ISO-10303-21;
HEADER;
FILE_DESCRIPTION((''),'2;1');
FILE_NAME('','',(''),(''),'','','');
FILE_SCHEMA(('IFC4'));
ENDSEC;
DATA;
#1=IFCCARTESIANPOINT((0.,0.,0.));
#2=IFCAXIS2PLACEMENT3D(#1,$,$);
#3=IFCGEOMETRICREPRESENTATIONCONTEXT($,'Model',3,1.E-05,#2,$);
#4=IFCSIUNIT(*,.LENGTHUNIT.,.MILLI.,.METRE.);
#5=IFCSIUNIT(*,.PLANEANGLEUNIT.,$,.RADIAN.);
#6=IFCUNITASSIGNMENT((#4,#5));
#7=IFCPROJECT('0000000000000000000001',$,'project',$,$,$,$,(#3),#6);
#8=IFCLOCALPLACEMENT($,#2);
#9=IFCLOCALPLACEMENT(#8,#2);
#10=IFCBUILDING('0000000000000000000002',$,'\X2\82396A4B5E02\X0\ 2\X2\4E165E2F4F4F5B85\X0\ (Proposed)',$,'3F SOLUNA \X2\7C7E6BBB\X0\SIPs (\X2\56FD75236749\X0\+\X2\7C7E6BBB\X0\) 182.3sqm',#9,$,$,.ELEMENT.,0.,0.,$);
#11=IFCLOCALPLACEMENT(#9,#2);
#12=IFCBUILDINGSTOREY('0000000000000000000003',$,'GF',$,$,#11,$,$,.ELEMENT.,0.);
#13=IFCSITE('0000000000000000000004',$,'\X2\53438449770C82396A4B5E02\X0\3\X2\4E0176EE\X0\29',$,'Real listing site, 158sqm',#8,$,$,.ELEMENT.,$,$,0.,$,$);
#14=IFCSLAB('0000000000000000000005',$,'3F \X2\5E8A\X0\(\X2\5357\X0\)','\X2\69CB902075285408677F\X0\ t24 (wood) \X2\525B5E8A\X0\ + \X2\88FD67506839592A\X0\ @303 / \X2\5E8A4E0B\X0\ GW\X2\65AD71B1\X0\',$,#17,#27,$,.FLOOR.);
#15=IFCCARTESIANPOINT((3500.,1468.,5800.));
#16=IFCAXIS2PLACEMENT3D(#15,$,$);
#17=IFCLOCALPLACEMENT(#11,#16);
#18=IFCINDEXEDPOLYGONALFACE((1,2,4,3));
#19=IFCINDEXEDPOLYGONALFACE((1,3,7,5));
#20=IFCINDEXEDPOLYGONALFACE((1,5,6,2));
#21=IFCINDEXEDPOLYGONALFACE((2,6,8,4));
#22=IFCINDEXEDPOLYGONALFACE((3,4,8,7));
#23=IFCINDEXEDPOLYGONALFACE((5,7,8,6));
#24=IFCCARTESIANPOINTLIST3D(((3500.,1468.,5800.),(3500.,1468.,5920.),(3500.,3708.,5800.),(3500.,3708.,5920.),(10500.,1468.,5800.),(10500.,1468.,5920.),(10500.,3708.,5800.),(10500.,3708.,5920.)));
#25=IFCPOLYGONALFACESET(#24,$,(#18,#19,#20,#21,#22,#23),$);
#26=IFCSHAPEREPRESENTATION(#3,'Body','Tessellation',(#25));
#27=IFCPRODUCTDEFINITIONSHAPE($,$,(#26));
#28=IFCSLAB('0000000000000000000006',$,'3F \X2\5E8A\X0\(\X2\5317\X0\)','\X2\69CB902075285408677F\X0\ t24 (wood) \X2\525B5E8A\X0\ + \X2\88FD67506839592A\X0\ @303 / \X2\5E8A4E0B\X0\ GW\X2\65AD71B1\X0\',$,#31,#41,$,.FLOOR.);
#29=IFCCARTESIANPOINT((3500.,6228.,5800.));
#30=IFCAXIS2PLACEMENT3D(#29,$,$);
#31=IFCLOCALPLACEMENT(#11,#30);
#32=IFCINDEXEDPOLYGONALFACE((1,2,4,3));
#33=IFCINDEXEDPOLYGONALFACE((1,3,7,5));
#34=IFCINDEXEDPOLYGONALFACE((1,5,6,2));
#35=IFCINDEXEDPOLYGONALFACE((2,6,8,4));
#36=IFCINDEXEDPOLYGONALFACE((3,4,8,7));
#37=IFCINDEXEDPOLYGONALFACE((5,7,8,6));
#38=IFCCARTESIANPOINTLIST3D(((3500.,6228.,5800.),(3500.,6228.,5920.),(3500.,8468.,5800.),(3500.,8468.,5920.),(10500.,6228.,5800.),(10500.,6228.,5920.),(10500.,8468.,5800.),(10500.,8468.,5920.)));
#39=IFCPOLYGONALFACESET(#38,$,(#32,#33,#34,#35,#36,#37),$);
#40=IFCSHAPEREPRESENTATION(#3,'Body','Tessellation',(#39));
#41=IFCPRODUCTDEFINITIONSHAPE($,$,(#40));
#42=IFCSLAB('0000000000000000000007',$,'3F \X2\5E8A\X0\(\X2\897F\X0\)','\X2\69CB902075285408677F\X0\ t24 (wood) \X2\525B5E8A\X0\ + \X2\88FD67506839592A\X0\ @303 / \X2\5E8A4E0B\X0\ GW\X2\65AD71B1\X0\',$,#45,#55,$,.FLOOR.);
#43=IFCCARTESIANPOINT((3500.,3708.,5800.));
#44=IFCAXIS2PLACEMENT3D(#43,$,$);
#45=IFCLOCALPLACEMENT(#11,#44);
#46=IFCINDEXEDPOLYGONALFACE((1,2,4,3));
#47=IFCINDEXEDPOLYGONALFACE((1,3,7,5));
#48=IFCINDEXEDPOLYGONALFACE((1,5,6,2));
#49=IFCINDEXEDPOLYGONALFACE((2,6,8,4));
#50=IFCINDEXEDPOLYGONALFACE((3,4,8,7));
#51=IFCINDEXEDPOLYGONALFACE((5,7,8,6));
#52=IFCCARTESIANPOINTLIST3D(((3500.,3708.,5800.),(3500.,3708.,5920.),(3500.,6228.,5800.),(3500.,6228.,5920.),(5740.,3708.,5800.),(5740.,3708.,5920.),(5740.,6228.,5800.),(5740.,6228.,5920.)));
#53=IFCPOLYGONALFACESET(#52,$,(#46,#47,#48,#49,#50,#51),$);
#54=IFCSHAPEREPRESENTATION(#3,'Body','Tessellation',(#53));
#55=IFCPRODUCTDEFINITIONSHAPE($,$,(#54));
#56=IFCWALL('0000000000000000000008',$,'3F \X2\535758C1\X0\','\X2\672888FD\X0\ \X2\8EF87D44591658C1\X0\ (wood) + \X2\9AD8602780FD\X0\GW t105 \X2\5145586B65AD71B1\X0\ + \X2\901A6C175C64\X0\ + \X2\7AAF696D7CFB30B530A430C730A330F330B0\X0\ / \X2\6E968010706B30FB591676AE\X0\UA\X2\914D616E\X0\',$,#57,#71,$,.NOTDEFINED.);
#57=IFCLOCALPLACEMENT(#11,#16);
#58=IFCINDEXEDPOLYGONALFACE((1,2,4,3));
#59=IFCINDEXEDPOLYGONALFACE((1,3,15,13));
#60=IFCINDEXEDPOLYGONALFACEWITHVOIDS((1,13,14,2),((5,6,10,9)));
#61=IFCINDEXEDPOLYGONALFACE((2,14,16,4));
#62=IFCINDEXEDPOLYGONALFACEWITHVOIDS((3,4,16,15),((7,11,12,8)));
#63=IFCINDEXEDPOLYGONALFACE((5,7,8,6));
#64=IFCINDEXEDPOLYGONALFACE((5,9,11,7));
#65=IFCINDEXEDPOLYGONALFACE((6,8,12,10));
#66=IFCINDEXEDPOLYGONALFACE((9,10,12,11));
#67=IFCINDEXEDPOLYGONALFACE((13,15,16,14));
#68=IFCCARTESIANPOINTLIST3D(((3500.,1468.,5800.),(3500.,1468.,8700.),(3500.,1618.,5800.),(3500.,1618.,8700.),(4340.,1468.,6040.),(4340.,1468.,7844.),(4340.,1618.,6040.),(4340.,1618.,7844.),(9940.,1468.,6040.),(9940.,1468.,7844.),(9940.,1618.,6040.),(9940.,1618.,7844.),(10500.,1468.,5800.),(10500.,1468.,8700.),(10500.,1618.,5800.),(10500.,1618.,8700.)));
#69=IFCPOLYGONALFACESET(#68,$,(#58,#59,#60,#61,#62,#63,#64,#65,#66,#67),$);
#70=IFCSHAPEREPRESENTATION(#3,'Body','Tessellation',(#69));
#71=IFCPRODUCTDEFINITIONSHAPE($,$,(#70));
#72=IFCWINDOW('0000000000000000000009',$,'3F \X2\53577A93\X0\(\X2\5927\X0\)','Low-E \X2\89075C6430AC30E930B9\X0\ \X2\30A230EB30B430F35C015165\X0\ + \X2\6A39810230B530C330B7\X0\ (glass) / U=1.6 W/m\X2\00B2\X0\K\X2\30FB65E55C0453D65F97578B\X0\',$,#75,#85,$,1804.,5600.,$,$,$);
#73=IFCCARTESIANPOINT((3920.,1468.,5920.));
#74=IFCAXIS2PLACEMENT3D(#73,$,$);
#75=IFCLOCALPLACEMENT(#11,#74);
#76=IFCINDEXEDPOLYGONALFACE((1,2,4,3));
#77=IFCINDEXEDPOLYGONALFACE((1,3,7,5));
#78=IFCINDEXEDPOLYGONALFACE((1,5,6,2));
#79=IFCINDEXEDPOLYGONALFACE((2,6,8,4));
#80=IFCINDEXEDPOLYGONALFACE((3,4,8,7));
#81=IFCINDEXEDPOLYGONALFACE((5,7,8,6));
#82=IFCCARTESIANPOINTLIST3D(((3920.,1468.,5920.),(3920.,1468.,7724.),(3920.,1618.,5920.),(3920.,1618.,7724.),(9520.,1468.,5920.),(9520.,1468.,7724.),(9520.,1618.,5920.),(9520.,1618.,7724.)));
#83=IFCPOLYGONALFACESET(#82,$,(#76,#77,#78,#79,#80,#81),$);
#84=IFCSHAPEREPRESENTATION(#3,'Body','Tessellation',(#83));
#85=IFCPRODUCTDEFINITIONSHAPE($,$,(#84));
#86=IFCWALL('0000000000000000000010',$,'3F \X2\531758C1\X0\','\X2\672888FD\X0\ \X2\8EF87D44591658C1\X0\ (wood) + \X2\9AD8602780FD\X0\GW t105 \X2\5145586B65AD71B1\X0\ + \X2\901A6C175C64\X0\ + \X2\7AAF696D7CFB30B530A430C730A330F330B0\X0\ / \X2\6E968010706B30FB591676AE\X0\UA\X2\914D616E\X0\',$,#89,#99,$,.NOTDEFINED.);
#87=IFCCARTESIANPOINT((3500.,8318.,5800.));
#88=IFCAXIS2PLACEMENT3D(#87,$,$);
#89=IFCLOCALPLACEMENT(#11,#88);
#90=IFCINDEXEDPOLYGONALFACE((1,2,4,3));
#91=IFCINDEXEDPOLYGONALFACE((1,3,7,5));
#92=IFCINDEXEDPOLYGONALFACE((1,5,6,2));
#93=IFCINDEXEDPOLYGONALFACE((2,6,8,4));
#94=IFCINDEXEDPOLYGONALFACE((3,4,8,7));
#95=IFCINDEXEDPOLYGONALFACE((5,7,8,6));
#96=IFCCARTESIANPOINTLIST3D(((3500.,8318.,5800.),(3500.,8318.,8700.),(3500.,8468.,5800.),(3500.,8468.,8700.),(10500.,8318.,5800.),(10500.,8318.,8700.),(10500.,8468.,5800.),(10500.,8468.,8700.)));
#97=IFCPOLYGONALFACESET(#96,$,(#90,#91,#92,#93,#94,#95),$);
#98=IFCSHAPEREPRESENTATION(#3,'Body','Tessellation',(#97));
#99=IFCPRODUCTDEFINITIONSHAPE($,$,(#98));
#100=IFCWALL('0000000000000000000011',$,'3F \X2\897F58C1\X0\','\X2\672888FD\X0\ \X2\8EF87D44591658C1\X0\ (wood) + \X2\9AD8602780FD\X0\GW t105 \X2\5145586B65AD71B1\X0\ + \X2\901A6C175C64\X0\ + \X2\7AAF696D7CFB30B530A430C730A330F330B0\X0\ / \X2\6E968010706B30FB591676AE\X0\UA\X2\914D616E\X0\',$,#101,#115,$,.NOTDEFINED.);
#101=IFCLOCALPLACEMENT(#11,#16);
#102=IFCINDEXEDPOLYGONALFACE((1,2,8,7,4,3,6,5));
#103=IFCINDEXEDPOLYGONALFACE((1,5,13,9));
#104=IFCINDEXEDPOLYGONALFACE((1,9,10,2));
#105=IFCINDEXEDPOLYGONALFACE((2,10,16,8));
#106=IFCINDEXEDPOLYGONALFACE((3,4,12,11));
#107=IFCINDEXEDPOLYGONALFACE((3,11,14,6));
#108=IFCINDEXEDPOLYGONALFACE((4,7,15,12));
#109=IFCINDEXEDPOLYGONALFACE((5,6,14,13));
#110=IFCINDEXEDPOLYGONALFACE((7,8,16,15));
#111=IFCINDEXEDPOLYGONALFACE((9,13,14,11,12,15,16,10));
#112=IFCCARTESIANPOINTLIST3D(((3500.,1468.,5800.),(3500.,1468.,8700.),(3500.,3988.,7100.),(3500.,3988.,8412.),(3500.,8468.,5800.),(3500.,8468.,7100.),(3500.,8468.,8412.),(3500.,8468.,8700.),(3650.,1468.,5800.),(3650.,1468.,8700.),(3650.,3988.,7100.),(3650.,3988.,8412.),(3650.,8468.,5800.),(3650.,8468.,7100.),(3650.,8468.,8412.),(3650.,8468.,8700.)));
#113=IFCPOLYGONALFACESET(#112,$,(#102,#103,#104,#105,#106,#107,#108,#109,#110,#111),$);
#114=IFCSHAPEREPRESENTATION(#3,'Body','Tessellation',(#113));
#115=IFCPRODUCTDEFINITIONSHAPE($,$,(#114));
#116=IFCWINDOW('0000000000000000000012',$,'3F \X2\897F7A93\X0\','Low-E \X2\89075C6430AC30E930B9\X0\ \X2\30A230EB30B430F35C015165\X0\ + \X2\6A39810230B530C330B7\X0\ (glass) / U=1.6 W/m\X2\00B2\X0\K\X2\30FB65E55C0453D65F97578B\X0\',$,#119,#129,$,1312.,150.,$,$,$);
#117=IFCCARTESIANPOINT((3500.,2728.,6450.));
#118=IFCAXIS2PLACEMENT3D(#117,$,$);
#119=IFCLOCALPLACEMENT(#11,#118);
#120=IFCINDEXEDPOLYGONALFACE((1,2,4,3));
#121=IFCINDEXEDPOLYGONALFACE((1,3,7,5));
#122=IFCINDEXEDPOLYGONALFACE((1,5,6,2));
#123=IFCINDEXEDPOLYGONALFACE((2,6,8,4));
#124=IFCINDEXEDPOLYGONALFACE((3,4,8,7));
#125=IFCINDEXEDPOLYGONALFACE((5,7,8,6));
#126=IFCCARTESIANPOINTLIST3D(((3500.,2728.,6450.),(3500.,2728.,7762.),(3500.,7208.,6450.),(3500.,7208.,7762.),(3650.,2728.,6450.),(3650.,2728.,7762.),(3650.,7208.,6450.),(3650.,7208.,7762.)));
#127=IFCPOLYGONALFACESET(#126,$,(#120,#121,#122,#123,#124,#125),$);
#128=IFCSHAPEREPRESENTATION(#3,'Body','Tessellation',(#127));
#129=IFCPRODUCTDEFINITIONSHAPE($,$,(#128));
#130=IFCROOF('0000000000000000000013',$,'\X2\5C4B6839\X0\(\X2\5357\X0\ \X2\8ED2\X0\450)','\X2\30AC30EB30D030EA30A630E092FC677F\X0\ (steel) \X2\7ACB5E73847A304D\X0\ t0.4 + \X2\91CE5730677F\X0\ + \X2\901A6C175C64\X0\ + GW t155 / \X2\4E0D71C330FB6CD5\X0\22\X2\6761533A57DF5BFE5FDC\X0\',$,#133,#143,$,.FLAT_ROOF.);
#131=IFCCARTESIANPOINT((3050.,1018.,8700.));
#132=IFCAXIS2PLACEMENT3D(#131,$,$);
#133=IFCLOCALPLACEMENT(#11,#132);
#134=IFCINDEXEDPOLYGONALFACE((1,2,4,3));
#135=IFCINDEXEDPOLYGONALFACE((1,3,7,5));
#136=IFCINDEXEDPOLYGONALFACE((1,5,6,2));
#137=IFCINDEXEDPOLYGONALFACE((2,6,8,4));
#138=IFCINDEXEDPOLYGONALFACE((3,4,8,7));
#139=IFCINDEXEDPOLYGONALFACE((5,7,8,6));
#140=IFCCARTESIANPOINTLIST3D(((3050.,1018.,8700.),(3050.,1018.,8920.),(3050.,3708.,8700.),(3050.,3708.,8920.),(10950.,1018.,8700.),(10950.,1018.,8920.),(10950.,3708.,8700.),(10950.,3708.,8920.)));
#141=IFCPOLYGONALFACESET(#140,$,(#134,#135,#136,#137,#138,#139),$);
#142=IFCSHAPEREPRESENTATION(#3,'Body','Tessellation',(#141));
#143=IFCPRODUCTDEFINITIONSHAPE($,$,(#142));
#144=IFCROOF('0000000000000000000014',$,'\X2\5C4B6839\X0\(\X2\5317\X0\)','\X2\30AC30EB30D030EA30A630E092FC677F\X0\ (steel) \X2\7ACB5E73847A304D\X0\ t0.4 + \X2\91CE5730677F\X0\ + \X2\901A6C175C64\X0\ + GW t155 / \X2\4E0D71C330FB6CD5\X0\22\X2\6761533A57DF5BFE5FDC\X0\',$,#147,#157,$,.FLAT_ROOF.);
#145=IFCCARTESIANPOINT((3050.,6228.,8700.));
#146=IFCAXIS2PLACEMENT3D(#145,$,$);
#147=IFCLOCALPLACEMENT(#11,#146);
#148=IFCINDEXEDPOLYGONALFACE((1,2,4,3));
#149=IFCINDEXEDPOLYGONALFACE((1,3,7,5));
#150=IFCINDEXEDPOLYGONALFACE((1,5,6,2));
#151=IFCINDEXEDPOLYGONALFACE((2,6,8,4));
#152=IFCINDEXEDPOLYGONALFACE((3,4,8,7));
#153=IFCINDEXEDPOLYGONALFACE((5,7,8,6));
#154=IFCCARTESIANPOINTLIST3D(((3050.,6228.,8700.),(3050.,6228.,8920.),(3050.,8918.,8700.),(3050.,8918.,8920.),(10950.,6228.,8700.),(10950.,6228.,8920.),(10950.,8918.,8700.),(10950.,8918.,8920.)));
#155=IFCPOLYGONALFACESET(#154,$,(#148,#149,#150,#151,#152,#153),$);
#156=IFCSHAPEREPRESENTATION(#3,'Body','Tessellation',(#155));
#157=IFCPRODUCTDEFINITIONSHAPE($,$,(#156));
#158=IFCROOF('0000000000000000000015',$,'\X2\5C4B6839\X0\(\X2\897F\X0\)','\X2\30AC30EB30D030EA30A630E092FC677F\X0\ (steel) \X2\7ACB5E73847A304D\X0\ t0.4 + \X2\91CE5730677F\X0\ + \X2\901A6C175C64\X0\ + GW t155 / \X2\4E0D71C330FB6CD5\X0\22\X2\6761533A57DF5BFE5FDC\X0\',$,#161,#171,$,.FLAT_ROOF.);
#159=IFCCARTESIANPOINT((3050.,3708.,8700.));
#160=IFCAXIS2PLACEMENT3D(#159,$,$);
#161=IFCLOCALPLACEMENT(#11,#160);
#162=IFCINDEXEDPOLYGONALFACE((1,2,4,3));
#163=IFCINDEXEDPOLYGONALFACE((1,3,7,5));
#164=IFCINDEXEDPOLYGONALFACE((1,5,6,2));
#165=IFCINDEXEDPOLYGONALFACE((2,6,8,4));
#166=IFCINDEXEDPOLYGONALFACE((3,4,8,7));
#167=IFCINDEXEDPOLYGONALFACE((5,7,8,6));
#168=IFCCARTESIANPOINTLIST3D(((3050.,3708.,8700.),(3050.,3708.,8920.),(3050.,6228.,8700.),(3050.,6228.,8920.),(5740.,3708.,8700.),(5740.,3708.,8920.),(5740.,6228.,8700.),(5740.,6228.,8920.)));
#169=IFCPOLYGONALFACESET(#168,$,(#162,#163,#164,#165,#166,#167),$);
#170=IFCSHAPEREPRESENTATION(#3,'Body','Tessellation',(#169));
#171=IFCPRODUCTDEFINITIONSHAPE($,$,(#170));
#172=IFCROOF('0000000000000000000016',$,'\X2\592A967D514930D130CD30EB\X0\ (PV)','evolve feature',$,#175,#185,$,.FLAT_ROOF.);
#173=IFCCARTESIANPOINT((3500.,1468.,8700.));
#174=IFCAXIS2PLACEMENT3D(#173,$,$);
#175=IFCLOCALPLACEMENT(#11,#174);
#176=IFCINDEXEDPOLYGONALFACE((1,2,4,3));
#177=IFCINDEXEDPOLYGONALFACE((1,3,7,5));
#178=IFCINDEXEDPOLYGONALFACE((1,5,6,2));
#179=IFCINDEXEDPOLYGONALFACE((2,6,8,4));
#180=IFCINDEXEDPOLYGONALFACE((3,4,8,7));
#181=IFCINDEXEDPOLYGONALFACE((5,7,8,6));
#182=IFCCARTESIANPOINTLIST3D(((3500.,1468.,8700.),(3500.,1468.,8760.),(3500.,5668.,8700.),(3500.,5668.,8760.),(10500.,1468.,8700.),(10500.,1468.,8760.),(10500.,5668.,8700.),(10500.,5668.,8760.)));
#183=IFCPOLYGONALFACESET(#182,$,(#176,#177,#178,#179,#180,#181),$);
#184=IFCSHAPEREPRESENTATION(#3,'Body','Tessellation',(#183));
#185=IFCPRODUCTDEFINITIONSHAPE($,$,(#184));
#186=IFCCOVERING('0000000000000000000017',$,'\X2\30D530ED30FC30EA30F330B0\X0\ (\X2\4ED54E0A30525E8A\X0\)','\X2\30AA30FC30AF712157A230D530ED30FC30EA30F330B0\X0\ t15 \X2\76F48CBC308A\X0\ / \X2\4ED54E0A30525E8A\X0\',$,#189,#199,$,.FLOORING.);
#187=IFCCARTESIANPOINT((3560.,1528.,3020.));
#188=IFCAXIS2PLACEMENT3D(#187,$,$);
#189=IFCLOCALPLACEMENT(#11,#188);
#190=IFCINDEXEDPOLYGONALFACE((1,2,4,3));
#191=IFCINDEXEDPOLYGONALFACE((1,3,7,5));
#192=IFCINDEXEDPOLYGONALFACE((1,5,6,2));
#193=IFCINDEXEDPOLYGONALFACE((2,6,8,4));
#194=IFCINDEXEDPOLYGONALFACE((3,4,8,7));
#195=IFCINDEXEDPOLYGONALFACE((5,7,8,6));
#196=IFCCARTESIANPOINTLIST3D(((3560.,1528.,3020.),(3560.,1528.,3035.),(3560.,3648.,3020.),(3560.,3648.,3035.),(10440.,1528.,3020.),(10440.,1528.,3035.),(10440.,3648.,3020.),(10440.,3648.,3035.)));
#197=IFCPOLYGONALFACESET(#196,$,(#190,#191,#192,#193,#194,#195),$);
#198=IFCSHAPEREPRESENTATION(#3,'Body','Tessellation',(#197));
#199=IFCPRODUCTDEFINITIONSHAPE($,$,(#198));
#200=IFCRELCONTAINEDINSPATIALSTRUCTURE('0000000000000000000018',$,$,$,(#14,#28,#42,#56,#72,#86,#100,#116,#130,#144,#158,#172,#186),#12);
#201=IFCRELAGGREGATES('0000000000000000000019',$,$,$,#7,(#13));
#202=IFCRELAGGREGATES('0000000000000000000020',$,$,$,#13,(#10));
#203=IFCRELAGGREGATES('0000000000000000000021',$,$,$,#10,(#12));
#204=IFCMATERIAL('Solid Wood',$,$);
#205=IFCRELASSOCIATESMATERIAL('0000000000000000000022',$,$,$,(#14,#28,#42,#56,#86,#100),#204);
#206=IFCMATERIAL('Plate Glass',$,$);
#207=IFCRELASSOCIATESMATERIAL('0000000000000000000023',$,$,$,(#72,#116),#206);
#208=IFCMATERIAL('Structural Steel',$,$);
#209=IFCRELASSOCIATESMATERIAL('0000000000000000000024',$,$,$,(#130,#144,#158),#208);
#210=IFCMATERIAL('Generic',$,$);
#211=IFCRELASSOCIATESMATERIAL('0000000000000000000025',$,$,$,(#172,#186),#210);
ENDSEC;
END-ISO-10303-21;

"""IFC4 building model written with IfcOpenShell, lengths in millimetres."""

from ifc_helpers import new_model, si_unit, frame, frame_2d, origin, place, context, project, spatial, rectangle, extrude, material, element, fill, save


model = new_model("IFC4")

# Units and contexts
model_context = context("Model", 3, precision=1e-05, world=origin())
ifc_project = project(units=[si_unit("LENGTHUNIT", "METRE", prefix="MILLI"), si_unit("PLANEANGLEUNIT", "RADIAN")], contexts=[model_context])

# Site, building, storey
site_placement = place(None, origin())
site = spatial("IfcSite", under=ifc_project, at=site_placement, Name="千葉県船橋市3丁目29", ObjectType="Real listing site, 158sqm", CompositionType="ELEMENT", RefElevation=0.0)
building_placement = place(site_placement, origin())
building = spatial("IfcBuilding", under=site, at=building_placement, Name="船橋市 2世帯住宅 (Proposed)", ObjectType="3F SOLUNA 籾殻SIPs (国産杉+籾殻) 182.3sqm", CompositionType="ELEMENT", ElevationOfRefHeight=0.0, ElevationOfTerrain=0.0)
storey_placement = place(building_placement, origin())
storey = spatial("IfcBuildingStorey", under=building, at=storey_placement, Name="GF", CompositionType="ELEMENT", Elevation=0.0)

# Slabs
ifc_material_1 = material(Name="Solid Wood")
slab_1_placement = place(storey_placement, frame((3500.0, 1468.0, 5800.0)))
element("IfcSlab", 1, at=slab_1_placement, inside=storey, material=ifc_material_1, Name="3F 床(南)", Description="構造用合板 t24 (wood) 剛床 + 製材根太 @303 / 床下 GW断熱", PredefinedType="FLOOR", context=model_context, shape_type="SweptSolid", body=[
    extrude(rectangle(XDim=7000.0, YDim=2240.0, at=frame_2d((3500.0, 1120.0))), frame((3500.0, 1468.0, 5800.0)), (0.0, 0.0, 1.0), 120.0),
])
slab_2_placement = place(storey_placement, frame((3500.0, 6228.0, 5800.0)))
element("IfcSlab", 2, at=slab_2_placement, inside=storey, material=ifc_material_1, Name="3F 床(北)", Description="構造用合板 t24 (wood) 剛床 + 製材根太 @303 / 床下 GW断熱", PredefinedType="FLOOR", context=model_context, shape_type="SweptSolid", body=[
    extrude(rectangle(XDim=7000.0, YDim=2240.0, at=frame_2d((3500.0, 1120.0))), frame((3500.0, 6228.0, 5800.0)), (0.0, 0.0, 1.0), 120.0),
])
slab_3_placement = place(storey_placement, frame((3500.0, 3708.0, 5800.0)))
element("IfcSlab", 3, at=slab_3_placement, inside=storey, material=ifc_material_1, Name="3F 床(西)", Description="構造用合板 t24 (wood) 剛床 + 製材根太 @303 / 床下 GW断熱", PredefinedType="FLOOR", context=model_context, shape_type="SweptSolid", body=[
    extrude(rectangle(XDim=2240.0, YDim=2520.0, at=frame_2d((1120.0, 1260.0))), frame((3500.0, 3708.0, 5800.0)), (0.0, 0.0, 1.0), 120.0),
])

# Wall, opening, window
wall_1_placement = place(storey_placement, frame((3500.0, 1468.0, 5800.0)))
wall_1 = element("IfcWall", 4, at=wall_1_placement, inside=storey, material=ifc_material_1, Name="3F 南壁", Description="木製 軸組外壁 (wood) + 高性能GW t105 充填断熱 + 通気層 + 窯業系サイディング / 準耐火・外皮UA配慮", PredefinedType="NOTDEFINED", context=model_context, shape_type="SweptSolid", body=[
    extrude(rectangle(XDim=7000.0, YDim=150.0, at=frame_2d((3500.0, 75.0))), frame((3500.0, 1468.0, 5800.0)), (0.0, 0.0, 1.0), 2900.0),
])
opening_1_placement = place(storey_placement, frame((3920.0, 1468.0, 5920.0)))
opening_1 = element("IfcOpeningElement", 5, at=opening_1_placement, cuts=wall_1, PredefinedType="NOTDEFINED", context=model_context, shape_type="SweptSolid", body=[
    extrude(rectangle(XDim=5600.0, YDim=150.0, at=frame_2d((2800.0, 75.0))), frame((3920.0, 1468.0, 5920.0)), (0.0, 0.0, 1.0), 1804.0),
])
ifc_material_2 = material(Name="Plate Glass")
window_1_placement = place(storey_placement, frame((3920.0, 1468.0, 5920.0)))
window_1 = element("IfcWindow", 6, at=window_1_placement, inside=storey, material=ifc_material_2, Name="3F 南窓(大)", Description="Low-E 複層ガラス アルゴン封入 + 樹脂サッシ (glass) / U=1.6 W/m²K・日射取得型", OverallHeight=1804.0, OverallWidth=5600.0, context=model_context, shape_type="SweptSolid", body=[
    extrude(rectangle(XDim=5600.0, YDim=150.0, at=frame_2d((2800.0, 75.0))), frame((3920.0, 1468.0, 5920.0)), (0.0, 0.0, 1.0), 1804.0),
])
fill(opening_1, window_1)

# Wall
wall_2_placement = place(storey_placement, frame((3500.0, 8318.0, 5800.0)))
element("IfcWall", 7, at=wall_2_placement, inside=storey, material=ifc_material_1, Name="3F 北壁", Description="木製 軸組外壁 (wood) + 高性能GW t105 充填断熱 + 通気層 + 窯業系サイディング / 準耐火・外皮UA配慮", PredefinedType="NOTDEFINED", context=model_context, shape_type="SweptSolid", body=[
    extrude(rectangle(XDim=7000.0, YDim=150.0, at=frame_2d((3500.0, 75.0))), frame((3500.0, 8318.0, 5800.0)), (0.0, 0.0, 1.0), 2900.0),
])

# Wall, opening, window
wall_3_placement = place(storey_placement, frame((3500.0, 1468.0, 5800.0)))
wall_3 = element("IfcWall", 8, at=wall_3_placement, inside=storey, material=ifc_material_1, Name="3F 西壁", Description="木製 軸組外壁 (wood) + 高性能GW t105 充填断熱 + 通気層 + 窯業系サイディング / 準耐火・外皮UA配慮", PredefinedType="NOTDEFINED", context=model_context, shape_type="SweptSolid", body=[
    extrude(rectangle(XDim=150.0, YDim=7000.0, at=frame_2d((75.0, 3500.0))), frame((3500.0, 1468.0, 5800.0)), (0.0, 0.0, 1.0), 2900.0),
])
opening_2_placement = place(storey_placement, frame((3500.0, 2728.0, 6450.0)))
opening_2 = element("IfcOpeningElement", 9, at=opening_2_placement, cuts=wall_3, PredefinedType="NOTDEFINED", context=model_context, shape_type="SweptSolid", body=[
    extrude(rectangle(XDim=150.0, YDim=4480.0, at=frame_2d((75.0, 2240.0))), frame((3500.0, 2728.0, 6450.0)), (0.0, 0.0, 1.0), 1312.0),
])
window_2_placement = place(storey_placement, frame((3500.0, 2728.0, 6450.0)))
window_2 = element("IfcWindow", 10, at=window_2_placement, inside=storey, material=ifc_material_2, Name="3F 西窓", Description="Low-E 複層ガラス アルゴン封入 + 樹脂サッシ (glass) / U=1.6 W/m²K・日射取得型", OverallHeight=1312.0, OverallWidth=150.0, context=model_context, shape_type="SweptSolid", body=[
    extrude(rectangle(XDim=150.0, YDim=4480.0, at=frame_2d((75.0, 2240.0))), frame((3500.0, 2728.0, 6450.0)), (0.0, 0.0, 1.0), 1312.0),
])
fill(opening_2, window_2)

# Roofs
ifc_material_3 = material(Name="Structural Steel")
roof_1_placement = place(storey_placement, frame((3050.0, 1018.0, 8700.0)))
element("IfcRoof", 11, at=roof_1_placement, inside=storey, material=ifc_material_3, Name="屋根(南 軒450)", Description="ガルバリウム鋼板 (steel) 立平葺き t0.4 + 野地板 + 通気層 + GW t155 / 不燃・法22条区域対応", PredefinedType="FLAT_ROOF", context=model_context, shape_type="SweptSolid", body=[
    extrude(rectangle(XDim=7900.0, YDim=2690.0, at=frame_2d((3950.0, 1345.0))), frame((3050.0, 1018.0, 8700.0)), (0.0, 0.0, 1.0), 220.0),
])
roof_2_placement = place(storey_placement, frame((3050.0, 6228.0, 8700.0)))
element("IfcRoof", 12, at=roof_2_placement, inside=storey, material=ifc_material_3, Name="屋根(北)", Description="ガルバリウム鋼板 (steel) 立平葺き t0.4 + 野地板 + 通気層 + GW t155 / 不燃・法22条区域対応", PredefinedType="FLAT_ROOF", context=model_context, shape_type="SweptSolid", body=[
    extrude(rectangle(XDim=7900.0, YDim=2690.0, at=frame_2d((3950.0, 1345.0))), frame((3050.0, 6228.0, 8700.0)), (0.0, 0.0, 1.0), 220.0),
])
roof_3_placement = place(storey_placement, frame((3050.0, 3708.0, 8700.0)))
element("IfcRoof", 13, at=roof_3_placement, inside=storey, material=ifc_material_3, Name="屋根(西)", Description="ガルバリウム鋼板 (steel) 立平葺き t0.4 + 野地板 + 通気層 + GW t155 / 不燃・法22条区域対応", PredefinedType="FLAT_ROOF", context=model_context, shape_type="SweptSolid", body=[
    extrude(rectangle(XDim=2690.0, YDim=2520.0, at=frame_2d((1345.0, 1260.0))), frame((3050.0, 3708.0, 8700.0)), (0.0, 0.0, 1.0), 220.0),
])
ifc_material_4 = material(Name="Generic")
roof_4_placement = place(storey_placement, frame((3500.0, 1468.0, 8700.0)))
element("IfcRoof", 14, at=roof_4_placement, inside=storey, material=ifc_material_4, Name="太陽光パネル (PV)", Description="evolve feature", PredefinedType="FLAT_ROOF", context=model_context, shape_type="SweptSolid", body=[
    extrude(rectangle(XDim=7000.0, YDim=4200.0, at=frame_2d((3500.0, 2100.0))), frame((3500.0, 1468.0, 8700.0)), (0.0, 0.0, 1.0), 60.0),
])

# Covering
covering_1_placement = place(storey_placement, frame((3560.0, 1528.0, 3020.0)))
element("IfcCovering", 15, at=covering_1_placement, inside=storey, material=ifc_material_4, Name="フローリング (仕上げ床)", Description="オーク無垢フローリング t15 直貼り / 仕上げ床", PredefinedType="FLOORING", context=model_context, shape_type="SweptSolid", body=[
    extrude(rectangle(XDim=6880.0, YDim=2120.0, at=frame_2d((3440.0, 1060.0))), frame((3560.0, 1528.0, 3020.0)), (0.0, 0.0, 1.0), 15.0),
])

save(model, "model.ifc")
